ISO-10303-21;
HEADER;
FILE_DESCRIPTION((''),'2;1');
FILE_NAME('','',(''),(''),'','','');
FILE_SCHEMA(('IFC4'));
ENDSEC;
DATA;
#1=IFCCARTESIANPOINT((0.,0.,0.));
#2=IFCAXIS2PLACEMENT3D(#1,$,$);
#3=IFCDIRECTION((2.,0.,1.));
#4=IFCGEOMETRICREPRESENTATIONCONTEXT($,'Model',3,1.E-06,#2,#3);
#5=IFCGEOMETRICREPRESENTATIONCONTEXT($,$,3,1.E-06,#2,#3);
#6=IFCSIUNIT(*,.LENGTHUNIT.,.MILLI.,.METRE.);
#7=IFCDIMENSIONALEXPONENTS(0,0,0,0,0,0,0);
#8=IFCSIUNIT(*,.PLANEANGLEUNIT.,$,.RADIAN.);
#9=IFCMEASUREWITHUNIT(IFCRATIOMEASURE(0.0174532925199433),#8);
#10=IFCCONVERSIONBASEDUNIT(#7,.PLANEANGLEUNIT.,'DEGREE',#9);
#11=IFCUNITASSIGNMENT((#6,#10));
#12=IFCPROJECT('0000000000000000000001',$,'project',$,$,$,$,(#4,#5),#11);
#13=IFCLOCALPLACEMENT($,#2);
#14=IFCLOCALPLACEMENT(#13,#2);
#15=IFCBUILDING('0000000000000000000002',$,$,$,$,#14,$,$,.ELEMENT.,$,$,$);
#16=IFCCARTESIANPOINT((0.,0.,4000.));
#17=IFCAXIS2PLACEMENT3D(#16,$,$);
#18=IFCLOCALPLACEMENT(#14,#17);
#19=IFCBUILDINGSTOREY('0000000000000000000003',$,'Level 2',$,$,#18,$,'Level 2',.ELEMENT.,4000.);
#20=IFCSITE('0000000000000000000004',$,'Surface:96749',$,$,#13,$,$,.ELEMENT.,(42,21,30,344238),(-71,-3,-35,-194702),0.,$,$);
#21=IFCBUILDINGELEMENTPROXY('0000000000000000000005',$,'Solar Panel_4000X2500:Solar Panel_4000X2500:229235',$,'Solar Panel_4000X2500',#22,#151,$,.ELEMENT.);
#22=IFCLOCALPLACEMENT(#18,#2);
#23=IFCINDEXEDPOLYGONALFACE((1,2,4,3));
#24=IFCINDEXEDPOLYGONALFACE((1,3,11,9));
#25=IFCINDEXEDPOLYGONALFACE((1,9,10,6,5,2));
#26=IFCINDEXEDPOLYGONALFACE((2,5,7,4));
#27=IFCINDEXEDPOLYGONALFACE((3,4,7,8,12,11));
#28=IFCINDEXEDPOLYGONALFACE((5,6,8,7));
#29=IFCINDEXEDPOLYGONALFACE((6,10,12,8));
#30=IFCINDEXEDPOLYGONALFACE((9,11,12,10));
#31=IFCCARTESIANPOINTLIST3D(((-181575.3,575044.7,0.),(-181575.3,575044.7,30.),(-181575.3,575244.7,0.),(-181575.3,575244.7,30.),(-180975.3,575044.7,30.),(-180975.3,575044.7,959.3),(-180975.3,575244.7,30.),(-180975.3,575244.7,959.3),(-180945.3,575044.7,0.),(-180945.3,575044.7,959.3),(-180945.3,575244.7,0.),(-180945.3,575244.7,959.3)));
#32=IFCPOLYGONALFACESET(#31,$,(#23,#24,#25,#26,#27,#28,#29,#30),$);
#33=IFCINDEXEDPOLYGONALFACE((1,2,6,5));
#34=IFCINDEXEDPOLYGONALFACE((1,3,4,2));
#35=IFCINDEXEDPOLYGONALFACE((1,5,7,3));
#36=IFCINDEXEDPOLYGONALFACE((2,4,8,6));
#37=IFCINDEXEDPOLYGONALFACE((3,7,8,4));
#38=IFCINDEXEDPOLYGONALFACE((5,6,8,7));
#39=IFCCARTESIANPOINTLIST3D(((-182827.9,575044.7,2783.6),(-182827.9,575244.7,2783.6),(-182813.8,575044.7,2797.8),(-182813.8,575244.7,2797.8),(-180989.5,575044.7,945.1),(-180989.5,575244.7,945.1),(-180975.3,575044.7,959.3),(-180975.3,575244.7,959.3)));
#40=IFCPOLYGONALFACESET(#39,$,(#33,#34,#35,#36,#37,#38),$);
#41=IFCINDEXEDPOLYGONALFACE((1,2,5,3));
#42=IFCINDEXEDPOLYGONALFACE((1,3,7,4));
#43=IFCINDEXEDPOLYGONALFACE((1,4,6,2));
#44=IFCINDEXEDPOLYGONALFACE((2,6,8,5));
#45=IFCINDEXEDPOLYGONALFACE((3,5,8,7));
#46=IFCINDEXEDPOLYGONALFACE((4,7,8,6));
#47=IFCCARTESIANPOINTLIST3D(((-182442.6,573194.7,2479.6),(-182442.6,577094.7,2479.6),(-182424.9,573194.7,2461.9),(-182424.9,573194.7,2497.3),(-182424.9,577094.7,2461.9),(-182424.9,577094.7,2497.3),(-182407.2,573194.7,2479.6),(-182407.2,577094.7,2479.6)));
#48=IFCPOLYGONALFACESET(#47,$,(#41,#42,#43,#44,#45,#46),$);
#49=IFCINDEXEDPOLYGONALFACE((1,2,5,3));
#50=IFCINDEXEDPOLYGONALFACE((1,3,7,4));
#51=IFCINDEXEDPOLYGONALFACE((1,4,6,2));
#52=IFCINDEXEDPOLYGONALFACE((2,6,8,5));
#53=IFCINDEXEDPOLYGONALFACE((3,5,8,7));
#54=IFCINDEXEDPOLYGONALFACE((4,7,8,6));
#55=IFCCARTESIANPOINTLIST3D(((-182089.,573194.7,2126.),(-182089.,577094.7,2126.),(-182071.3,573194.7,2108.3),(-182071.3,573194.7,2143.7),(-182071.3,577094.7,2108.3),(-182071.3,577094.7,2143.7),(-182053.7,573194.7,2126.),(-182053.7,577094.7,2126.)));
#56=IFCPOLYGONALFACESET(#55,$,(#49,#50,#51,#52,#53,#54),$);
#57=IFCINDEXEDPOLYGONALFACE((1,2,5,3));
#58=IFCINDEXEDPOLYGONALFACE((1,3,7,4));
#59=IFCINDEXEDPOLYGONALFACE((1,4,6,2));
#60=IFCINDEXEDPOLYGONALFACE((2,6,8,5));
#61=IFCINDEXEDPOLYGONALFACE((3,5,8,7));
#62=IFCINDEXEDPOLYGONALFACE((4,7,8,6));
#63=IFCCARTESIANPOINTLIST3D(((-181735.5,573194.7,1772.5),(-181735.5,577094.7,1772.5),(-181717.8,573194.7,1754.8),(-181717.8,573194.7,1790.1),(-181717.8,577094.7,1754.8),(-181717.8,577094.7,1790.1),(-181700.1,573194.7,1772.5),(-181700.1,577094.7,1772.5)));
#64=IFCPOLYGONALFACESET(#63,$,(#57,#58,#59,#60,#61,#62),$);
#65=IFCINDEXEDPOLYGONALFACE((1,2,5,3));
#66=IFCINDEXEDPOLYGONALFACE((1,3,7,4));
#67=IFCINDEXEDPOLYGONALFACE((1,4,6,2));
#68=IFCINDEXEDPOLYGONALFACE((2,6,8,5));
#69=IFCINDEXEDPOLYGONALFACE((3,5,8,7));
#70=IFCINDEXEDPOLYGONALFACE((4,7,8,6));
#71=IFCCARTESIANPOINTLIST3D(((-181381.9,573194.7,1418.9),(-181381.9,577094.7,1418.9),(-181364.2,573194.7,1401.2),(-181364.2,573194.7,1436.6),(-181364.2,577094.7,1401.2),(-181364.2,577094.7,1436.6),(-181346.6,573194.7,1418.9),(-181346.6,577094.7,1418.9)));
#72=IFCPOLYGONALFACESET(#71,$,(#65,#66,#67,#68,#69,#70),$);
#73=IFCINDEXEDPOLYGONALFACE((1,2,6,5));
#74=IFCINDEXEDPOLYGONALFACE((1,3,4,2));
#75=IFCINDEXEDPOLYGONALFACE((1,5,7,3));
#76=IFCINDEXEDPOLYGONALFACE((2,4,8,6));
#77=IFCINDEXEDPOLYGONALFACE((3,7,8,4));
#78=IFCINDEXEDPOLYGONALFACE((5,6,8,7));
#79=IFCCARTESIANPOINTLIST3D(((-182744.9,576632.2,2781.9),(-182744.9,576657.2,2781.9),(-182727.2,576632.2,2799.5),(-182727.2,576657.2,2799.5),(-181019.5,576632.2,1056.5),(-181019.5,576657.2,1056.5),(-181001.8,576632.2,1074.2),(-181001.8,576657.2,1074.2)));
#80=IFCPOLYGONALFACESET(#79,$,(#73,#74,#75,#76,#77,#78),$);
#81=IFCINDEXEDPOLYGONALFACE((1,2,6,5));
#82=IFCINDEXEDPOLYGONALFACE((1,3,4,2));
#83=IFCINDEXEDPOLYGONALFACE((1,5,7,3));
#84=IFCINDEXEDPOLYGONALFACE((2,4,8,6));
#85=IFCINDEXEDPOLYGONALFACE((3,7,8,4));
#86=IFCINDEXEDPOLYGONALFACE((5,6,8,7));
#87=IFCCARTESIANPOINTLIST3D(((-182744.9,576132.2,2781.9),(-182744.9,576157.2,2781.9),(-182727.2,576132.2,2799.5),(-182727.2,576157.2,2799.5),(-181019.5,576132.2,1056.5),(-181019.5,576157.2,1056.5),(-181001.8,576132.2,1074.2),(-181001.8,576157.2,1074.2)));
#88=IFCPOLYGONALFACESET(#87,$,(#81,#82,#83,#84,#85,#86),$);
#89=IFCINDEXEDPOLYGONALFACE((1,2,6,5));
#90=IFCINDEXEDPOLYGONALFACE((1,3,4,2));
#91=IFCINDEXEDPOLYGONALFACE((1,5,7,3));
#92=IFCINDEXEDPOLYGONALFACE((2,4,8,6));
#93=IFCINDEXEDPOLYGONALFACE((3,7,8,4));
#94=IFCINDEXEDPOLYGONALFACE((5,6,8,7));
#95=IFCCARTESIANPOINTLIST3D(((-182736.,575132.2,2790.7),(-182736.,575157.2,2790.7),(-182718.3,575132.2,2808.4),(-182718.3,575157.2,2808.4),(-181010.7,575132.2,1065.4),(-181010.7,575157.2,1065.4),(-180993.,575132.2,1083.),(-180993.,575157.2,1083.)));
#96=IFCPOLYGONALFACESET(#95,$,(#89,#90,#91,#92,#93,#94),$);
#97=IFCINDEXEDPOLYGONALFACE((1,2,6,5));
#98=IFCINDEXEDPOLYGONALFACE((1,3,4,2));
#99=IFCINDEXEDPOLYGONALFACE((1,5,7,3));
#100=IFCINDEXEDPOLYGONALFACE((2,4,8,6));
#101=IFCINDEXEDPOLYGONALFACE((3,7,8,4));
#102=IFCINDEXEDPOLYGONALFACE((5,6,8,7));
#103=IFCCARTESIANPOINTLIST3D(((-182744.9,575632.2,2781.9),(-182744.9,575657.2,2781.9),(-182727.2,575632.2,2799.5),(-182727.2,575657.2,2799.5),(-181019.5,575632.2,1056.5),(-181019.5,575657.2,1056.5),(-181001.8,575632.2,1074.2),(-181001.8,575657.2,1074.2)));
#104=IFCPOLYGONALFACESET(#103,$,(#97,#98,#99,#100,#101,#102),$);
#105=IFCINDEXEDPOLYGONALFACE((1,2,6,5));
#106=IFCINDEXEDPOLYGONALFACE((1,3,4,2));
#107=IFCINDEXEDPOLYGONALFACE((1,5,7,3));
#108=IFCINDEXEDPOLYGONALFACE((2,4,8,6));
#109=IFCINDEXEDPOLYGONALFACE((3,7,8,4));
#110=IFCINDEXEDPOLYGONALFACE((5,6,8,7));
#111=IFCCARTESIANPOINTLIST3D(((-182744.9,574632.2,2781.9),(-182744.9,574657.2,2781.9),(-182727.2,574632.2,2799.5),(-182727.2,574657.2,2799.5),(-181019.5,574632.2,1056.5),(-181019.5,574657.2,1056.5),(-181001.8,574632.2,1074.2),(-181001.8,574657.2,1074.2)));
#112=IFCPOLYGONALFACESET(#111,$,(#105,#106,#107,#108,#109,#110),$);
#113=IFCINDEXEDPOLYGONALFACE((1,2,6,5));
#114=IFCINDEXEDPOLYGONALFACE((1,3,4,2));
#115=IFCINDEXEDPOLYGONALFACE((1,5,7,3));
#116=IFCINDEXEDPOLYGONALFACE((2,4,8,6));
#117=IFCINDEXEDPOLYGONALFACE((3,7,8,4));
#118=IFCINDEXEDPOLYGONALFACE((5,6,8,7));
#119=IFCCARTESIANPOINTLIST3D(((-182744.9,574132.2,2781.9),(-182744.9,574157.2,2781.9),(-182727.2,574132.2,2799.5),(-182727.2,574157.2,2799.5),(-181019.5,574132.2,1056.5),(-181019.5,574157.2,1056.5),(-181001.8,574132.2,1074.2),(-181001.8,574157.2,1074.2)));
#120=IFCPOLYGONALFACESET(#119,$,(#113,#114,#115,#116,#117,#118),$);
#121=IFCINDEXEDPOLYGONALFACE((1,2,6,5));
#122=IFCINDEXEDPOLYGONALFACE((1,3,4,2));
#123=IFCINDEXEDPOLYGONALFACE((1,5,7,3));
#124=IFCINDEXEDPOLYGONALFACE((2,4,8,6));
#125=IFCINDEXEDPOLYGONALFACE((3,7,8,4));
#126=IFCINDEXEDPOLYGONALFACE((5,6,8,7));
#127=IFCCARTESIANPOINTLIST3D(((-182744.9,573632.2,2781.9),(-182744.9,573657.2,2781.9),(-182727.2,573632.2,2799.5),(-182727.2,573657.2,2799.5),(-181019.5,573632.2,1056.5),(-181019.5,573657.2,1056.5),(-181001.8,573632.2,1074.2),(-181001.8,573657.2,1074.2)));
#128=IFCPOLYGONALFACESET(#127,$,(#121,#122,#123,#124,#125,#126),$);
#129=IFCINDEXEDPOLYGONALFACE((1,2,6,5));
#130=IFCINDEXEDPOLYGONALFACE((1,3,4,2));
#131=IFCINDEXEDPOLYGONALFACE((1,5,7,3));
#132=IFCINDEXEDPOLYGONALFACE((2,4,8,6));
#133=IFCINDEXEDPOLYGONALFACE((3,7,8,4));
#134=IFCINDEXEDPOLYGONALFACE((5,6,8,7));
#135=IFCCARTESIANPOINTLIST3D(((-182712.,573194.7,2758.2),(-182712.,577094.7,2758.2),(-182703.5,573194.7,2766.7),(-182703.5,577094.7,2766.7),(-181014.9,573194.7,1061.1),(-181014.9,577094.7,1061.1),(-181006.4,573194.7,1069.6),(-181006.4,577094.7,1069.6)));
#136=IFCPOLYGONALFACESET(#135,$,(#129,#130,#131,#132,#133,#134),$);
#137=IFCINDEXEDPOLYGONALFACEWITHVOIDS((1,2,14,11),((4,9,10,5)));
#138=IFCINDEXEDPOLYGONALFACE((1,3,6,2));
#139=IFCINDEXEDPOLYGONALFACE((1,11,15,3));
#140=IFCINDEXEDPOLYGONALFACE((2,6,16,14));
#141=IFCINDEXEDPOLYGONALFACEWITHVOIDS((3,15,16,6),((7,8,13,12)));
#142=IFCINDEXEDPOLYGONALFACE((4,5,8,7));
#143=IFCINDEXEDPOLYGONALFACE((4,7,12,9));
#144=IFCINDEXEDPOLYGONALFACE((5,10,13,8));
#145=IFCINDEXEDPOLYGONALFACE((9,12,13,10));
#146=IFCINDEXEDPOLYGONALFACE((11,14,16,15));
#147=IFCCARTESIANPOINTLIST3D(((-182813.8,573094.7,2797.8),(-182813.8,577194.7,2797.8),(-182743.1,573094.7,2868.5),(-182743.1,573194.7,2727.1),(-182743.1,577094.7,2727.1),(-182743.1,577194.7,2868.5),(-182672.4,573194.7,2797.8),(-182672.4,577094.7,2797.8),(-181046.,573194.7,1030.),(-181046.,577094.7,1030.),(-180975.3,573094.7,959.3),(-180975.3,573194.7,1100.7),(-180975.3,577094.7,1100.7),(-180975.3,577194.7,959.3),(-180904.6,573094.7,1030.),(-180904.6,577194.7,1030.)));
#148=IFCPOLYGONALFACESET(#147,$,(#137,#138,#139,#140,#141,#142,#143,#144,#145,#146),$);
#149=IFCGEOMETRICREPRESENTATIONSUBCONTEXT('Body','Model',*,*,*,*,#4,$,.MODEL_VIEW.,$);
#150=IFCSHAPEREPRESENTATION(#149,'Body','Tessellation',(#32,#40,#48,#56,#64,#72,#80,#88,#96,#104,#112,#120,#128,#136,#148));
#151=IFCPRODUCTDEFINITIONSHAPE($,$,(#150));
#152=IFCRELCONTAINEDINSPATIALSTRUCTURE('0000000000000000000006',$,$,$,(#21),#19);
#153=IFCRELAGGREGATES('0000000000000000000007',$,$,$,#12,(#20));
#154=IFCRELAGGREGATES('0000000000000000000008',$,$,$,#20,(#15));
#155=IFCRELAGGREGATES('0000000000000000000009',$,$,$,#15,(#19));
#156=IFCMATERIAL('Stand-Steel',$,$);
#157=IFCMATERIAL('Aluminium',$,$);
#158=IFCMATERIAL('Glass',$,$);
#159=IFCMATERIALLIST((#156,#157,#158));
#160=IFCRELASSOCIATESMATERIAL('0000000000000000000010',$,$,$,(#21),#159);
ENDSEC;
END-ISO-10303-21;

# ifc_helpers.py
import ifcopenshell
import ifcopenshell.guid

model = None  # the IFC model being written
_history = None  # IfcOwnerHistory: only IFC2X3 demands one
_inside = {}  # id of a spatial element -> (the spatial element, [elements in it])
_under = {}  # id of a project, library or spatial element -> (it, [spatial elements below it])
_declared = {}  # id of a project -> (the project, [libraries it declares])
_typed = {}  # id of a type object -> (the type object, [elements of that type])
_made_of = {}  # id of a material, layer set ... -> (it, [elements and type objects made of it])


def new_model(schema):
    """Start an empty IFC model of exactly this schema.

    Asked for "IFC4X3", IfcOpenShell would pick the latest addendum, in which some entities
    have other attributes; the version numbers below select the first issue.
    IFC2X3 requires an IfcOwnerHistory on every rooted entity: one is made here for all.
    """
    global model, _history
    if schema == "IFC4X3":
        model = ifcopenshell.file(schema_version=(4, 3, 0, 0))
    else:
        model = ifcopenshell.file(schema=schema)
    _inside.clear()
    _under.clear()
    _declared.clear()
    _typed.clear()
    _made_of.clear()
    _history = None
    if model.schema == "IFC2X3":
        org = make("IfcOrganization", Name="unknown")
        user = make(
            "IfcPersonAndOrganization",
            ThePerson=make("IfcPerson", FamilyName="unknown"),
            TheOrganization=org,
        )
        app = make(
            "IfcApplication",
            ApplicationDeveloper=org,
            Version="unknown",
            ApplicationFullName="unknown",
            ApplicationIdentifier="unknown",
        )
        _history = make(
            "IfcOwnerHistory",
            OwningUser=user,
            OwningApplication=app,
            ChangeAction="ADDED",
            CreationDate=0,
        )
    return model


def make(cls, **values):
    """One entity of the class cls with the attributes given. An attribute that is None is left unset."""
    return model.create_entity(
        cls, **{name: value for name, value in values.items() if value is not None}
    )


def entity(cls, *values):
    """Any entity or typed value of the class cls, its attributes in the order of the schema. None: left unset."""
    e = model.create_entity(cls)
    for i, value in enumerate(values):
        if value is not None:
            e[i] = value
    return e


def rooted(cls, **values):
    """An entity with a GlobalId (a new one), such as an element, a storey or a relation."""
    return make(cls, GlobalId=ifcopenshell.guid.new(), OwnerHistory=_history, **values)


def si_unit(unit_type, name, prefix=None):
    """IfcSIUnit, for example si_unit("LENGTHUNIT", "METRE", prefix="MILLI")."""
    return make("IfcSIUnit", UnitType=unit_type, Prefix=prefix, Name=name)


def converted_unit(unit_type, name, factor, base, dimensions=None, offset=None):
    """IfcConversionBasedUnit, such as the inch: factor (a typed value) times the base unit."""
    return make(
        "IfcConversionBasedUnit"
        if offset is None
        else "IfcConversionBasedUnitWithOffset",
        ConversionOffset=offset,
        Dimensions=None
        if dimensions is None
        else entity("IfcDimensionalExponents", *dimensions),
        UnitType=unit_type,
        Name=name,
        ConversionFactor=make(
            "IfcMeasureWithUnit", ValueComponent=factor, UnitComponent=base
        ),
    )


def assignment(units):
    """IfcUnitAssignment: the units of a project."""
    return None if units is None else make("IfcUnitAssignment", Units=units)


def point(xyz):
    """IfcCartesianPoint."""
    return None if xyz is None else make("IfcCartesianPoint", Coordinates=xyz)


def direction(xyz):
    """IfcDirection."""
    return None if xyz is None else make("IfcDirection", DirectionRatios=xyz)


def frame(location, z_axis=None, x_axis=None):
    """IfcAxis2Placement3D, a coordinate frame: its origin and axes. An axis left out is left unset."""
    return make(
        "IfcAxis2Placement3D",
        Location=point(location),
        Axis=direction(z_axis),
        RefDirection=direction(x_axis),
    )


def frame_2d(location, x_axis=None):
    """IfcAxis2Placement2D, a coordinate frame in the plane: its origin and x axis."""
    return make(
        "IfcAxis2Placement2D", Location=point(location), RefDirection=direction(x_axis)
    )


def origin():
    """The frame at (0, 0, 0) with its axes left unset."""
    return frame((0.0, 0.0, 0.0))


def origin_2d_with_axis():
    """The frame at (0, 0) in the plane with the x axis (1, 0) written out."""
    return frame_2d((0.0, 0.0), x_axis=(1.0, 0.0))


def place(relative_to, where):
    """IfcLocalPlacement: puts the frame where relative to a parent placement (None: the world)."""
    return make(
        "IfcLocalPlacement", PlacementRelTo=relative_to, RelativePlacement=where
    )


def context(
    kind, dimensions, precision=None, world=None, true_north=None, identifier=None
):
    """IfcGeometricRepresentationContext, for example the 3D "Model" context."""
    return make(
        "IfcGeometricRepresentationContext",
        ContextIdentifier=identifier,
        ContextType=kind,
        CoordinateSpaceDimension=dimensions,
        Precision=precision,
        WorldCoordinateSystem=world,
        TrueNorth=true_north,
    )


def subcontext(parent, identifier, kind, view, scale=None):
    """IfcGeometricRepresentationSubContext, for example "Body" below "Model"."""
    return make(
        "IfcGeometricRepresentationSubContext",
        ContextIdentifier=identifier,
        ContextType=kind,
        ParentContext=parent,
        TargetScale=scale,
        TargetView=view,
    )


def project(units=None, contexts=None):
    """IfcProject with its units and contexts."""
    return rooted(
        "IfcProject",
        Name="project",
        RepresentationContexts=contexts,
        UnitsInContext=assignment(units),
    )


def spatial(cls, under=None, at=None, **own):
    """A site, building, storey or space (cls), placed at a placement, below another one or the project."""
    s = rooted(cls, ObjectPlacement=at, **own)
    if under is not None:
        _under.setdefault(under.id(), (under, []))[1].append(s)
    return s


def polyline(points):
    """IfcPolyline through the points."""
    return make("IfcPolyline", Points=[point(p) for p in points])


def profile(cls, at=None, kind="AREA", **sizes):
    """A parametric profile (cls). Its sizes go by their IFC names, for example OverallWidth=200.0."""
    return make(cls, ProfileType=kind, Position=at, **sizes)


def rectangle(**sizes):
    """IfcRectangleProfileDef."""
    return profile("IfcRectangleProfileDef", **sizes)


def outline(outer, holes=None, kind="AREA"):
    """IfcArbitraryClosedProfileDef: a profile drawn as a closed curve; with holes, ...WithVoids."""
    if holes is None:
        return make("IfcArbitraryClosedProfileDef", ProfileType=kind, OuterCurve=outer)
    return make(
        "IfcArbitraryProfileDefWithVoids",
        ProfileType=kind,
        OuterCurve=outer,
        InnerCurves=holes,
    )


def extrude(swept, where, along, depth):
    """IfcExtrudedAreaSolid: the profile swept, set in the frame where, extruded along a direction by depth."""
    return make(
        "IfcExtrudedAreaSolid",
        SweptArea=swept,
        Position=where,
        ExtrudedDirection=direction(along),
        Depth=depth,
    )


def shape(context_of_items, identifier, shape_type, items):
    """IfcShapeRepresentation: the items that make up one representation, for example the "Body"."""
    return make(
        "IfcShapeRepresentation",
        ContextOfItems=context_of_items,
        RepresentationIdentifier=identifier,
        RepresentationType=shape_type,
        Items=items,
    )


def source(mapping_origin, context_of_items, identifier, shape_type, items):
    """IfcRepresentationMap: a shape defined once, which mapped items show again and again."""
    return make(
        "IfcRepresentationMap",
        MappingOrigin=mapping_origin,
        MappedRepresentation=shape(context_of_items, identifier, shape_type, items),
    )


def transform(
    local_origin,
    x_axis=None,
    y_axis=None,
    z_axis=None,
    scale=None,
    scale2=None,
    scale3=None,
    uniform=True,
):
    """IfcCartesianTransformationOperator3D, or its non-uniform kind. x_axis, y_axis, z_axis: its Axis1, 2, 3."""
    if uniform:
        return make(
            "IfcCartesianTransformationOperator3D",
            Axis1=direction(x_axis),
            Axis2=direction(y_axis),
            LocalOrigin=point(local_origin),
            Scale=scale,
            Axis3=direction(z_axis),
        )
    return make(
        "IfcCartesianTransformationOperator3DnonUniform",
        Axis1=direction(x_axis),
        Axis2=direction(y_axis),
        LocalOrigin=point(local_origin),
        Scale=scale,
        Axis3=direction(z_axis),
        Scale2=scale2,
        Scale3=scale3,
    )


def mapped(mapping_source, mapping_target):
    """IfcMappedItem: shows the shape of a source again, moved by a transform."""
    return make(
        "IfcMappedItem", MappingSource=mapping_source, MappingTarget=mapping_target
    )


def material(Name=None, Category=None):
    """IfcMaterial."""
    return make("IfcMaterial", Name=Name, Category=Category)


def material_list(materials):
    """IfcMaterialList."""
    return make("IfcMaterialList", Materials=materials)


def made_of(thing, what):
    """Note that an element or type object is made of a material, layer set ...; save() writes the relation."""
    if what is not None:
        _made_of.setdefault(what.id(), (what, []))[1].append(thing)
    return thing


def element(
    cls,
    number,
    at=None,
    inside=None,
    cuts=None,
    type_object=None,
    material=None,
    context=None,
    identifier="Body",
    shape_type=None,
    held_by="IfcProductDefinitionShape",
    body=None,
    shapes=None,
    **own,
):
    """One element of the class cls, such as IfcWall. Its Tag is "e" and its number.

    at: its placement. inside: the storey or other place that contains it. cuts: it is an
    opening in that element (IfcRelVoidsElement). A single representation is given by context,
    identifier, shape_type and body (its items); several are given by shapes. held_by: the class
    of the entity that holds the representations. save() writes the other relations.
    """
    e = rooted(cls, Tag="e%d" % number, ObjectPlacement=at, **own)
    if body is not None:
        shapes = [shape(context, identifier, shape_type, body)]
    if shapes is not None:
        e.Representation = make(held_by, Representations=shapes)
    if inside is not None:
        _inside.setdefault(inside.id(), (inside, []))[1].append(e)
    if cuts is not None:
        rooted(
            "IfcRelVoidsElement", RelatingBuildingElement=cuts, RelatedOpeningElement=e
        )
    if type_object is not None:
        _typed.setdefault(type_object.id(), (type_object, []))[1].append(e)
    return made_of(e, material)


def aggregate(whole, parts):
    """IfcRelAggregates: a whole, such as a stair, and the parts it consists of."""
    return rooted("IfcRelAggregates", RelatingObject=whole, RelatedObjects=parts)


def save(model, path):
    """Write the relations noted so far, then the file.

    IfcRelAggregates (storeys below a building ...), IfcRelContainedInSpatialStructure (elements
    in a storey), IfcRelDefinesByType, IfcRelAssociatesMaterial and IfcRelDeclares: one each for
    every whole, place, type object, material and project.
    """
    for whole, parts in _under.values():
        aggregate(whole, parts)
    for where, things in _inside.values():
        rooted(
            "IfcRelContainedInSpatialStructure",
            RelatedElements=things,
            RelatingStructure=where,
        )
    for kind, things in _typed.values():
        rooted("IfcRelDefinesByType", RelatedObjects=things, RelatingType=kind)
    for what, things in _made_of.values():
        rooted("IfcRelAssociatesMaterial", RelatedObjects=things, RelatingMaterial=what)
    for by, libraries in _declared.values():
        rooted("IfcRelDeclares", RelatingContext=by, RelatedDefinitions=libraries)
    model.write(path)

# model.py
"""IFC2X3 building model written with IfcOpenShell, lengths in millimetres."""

from ifc_helpers import new_model, entity, si_unit, converted_unit, direction, frame, frame_2d, origin, origin_2d_with_axis, place, context, subcontext, project, spatial, polyline, rectangle, outline, extrude, source, transform, mapped, material, material_list, element, save


model = new_model("IFC2X3")

# Units and contexts
model_context = context("Model", 3, precision=1e-06, world=origin(), true_north=direction((2.0, 0.0, 1.0)))
context_of_model = context(None, 3, precision=1e-06, world=origin(), true_north=direction((2.0, 0.0, 1.0)))
body_context = subcontext(model_context, "Body", "Model", "MODEL_VIEW")
ifc_project = project(units=[si_unit("LENGTHUNIT", "METRE", prefix="MILLI"), converted_unit("PLANEANGLEUNIT", "DEGREE", entity("IfcRatioMeasure", 0.0174532925199433), si_unit("PLANEANGLEUNIT", "RADIAN"), dimensions=[0, 0, 0, 0, 0, 0, 0])], contexts=[model_context, context_of_model])

# Site, building, storey
site_placement = place(None, origin())
site = spatial("IfcSite", under=ifc_project, at=site_placement, Name="Surface:96749", CompositionType="ELEMENT", RefLatitude=(42, 21, 30, 344238), RefLongitude=(-71, -3, -35, -194702), RefElevation=0.0)
building_placement = place(site_placement, origin())
building = spatial("IfcBuilding", under=site, at=building_placement, CompositionType="ELEMENT")
storey_placement = place(building_placement, frame((0.0, 0.0, 4000.0)))
storey = spatial("IfcBuildingStorey", under=building, at=storey_placement, Name="Level 2", LongName="Level 2", CompositionType="ELEMENT", Elevation=4000.0)

# Building element proxy
ifc_material_1 = material(Name="Stand-Steel")
ifc_material_2 = material(Name="Aluminium")
ifc_material_3 = material(Name="Glass")
ifc_material_list_1 = material_list([ifc_material_1, ifc_material_2, ifc_material_3])
shared_shape = source(origin(), body_context, "Body", "SweptSolid", [
    extrude(outline(polyline([(-629.5, -220.0), (329.8, -220.0), (329.8, 410.0), (299.8, 410.0), (299.8, -190.0), (-629.5, -190.0), (-629.5, -220.0)])), frame((-190.0, -100.0, 299.8), z_axis=(0.0, 1.0, 0.0), x_axis=(0.0, 0.0, -1.0)), (0.0, 0.0, 1.0), 200.0),
    extrude(rectangle(XDim=20.0, YDim=200.0, at=frame_2d((0.0, 0.0), x_axis=(0.0, 1.0))), frame((-7.1, 0.0, 922.2), z_axis=(-0.707107, 0.0, 0.707107), x_axis=(0.0, 1.0, 0.0)), (0.0, 0.0, 1.0), 2600.0),
    extrude(rectangle(XDim=25.0, YDim=25.0, at=frame_2d((0.0, 0.0), x_axis=(1.0, 0.0))), frame((-1449.6, -1950.0, 2449.6), z_axis=(0.0, 1.0, 0.0), x_axis=(-0.707107, 0.0, -0.707107)), (0.0, 0.0, 1.0), 3900.0),
    extrude(rectangle(XDim=25.0, YDim=25.0, at=origin_2d_with_axis()), frame((-1096.0, -1950.0, 2096.0), z_axis=(0.0, 1.0, 0.0), x_axis=(-0.707107, 0.0, -0.707107)), (0.0, 0.0, 1.0), 3900.0),
    extrude(rectangle(XDim=25.0, YDim=25.0, at=origin_2d_with_axis()), frame((-742.5, -1950.0, 1742.5), z_axis=(0.0, 1.0, 0.0), x_axis=(-0.707107, 0.0, -0.707107)), (0.0, 0.0, 1.0), 3900.0),
    extrude(rectangle(XDim=25.0, YDim=25.0, at=frame_2d((0.0, 0.0), x_axis=(1.0, 0.0))), frame((-388.9, -1950.0, 1388.9), z_axis=(0.0, 1.0, 0.0), x_axis=(-0.707107, 0.0, -0.707107)), (0.0, 0.0, 1.0), 3900.0),
    extrude(rectangle(XDim=25.0, YDim=25.0, at=frame_2d((0.0, 0.0), x_axis=(0.0, 1.0))), frame((-35.4, 1500.0, 1035.4), z_axis=(-0.707107, 0.0, 0.707107), x_axis=(0.0, 1.0, 0.0)), (0.0, 0.0, 1.0), 2440.0),
    extrude(rectangle(XDim=25.0, YDim=25.0, at=frame_2d((0.0, 0.0), x_axis=(0.0, 1.0))), frame((-35.4, 1000.0, 1035.4), z_axis=(-0.707107, 0.0, 0.707107), x_axis=(0.0, 1.0, 0.0)), (0.0, 0.0, 1.0), 2440.0),
    extrude(rectangle(XDim=25.0, YDim=25.0, at=frame_2d((0.0, 0.0), x_axis=(0.0, 1.0))), frame((-26.5, 0.0, 1044.2), z_axis=(-0.707107, 0.0, 0.707107), x_axis=(0.0, -1.0, 0.0)), (0.0, 0.0, 1.0), 2440.0),
    extrude(rectangle(XDim=25.0, YDim=25.0, at=frame_2d((0.0, 0.0), x_axis=(0.0, 1.0))), frame((-35.4, 500.0, 1035.4), z_axis=(-0.707107, 0.0, 0.707107), x_axis=(0.0, 1.0, 0.0)), (0.0, 0.0, 1.0), 2440.0),
    extrude(rectangle(XDim=25.0, YDim=25.0, at=frame_2d((0.0, 0.0), x_axis=(0.0, 1.0))), frame((-35.4, -500.0, 1035.4), z_axis=(-0.707107, 0.0, 0.707107), x_axis=(0.0, 1.0, 0.0)), (0.0, 0.0, 1.0), 2440.0),
    extrude(rectangle(XDim=25.0, YDim=25.0, at=frame_2d((0.0, 0.0), x_axis=(0.0, 1.0))), frame((-35.4, -1000.0, 1035.4), z_axis=(-0.707107, 0.0, 0.707107), x_axis=(0.0, 1.0, 0.0)), (0.0, 0.0, 1.0), 2440.0),
    extrude(rectangle(XDim=25.0, YDim=25.0, at=frame_2d((0.0, 0.0), x_axis=(0.0, 1.0))), frame((-35.4, -1500.0, 1035.4), z_axis=(-0.707107, 0.0, 0.707107), x_axis=(0.0, 1.0, 0.0)), (0.0, 0.0, 1.0), 2440.0),
    extrude(rectangle(XDim=2400.0, YDim=12.0, at=frame_2d((0.0, 0.0), x_axis=(1.0, 0.0))), frame((-883.9, -1950.0, 1883.9), z_axis=(0.0, 1.0, 0.0), x_axis=(0.707107, 0.0, -0.707107)), (0.0, 0.0, 1.0), 3900.0),
    extrude(outline(polyline([(-2050.0, -1300.0), (2050.0, -1300.0), (2050.0, 1300.0), (-2050.0, 1300.0), (-2050.0, -1300.0)]), holes=[polyline([(1950.0, -1200.0), (-1950.0, -1200.0), (-1950.0, 1200.0), (1950.0, 1200.0), (1950.0, -1200.0)])]), frame((-919.2, 0.0, 1848.5), z_axis=(0.707107, 0.0, 0.707107), x_axis=(0.0, 1.0, 0.0)), (0.0, 0.0, 1.0), 100.0),
])
proxy_1_placement = place(storey_placement, frame((-180975.3, 575144.7, 30.0)))
element("IfcBuildingElementProxy", 1, at=proxy_1_placement, inside=storey, material=ifc_material_list_1, Name="Solar Panel_4000X2500:Solar Panel_4000X2500:229235", ObjectType="Solar Panel_4000X2500", CompositionType="ELEMENT", context=body_context, shape_type="MappedRepresentation", body=[
    mapped(shared_shape, transform((0.0, 0.0, 0.0), scale=1.0)),
])

save(model, "model.ifc")
